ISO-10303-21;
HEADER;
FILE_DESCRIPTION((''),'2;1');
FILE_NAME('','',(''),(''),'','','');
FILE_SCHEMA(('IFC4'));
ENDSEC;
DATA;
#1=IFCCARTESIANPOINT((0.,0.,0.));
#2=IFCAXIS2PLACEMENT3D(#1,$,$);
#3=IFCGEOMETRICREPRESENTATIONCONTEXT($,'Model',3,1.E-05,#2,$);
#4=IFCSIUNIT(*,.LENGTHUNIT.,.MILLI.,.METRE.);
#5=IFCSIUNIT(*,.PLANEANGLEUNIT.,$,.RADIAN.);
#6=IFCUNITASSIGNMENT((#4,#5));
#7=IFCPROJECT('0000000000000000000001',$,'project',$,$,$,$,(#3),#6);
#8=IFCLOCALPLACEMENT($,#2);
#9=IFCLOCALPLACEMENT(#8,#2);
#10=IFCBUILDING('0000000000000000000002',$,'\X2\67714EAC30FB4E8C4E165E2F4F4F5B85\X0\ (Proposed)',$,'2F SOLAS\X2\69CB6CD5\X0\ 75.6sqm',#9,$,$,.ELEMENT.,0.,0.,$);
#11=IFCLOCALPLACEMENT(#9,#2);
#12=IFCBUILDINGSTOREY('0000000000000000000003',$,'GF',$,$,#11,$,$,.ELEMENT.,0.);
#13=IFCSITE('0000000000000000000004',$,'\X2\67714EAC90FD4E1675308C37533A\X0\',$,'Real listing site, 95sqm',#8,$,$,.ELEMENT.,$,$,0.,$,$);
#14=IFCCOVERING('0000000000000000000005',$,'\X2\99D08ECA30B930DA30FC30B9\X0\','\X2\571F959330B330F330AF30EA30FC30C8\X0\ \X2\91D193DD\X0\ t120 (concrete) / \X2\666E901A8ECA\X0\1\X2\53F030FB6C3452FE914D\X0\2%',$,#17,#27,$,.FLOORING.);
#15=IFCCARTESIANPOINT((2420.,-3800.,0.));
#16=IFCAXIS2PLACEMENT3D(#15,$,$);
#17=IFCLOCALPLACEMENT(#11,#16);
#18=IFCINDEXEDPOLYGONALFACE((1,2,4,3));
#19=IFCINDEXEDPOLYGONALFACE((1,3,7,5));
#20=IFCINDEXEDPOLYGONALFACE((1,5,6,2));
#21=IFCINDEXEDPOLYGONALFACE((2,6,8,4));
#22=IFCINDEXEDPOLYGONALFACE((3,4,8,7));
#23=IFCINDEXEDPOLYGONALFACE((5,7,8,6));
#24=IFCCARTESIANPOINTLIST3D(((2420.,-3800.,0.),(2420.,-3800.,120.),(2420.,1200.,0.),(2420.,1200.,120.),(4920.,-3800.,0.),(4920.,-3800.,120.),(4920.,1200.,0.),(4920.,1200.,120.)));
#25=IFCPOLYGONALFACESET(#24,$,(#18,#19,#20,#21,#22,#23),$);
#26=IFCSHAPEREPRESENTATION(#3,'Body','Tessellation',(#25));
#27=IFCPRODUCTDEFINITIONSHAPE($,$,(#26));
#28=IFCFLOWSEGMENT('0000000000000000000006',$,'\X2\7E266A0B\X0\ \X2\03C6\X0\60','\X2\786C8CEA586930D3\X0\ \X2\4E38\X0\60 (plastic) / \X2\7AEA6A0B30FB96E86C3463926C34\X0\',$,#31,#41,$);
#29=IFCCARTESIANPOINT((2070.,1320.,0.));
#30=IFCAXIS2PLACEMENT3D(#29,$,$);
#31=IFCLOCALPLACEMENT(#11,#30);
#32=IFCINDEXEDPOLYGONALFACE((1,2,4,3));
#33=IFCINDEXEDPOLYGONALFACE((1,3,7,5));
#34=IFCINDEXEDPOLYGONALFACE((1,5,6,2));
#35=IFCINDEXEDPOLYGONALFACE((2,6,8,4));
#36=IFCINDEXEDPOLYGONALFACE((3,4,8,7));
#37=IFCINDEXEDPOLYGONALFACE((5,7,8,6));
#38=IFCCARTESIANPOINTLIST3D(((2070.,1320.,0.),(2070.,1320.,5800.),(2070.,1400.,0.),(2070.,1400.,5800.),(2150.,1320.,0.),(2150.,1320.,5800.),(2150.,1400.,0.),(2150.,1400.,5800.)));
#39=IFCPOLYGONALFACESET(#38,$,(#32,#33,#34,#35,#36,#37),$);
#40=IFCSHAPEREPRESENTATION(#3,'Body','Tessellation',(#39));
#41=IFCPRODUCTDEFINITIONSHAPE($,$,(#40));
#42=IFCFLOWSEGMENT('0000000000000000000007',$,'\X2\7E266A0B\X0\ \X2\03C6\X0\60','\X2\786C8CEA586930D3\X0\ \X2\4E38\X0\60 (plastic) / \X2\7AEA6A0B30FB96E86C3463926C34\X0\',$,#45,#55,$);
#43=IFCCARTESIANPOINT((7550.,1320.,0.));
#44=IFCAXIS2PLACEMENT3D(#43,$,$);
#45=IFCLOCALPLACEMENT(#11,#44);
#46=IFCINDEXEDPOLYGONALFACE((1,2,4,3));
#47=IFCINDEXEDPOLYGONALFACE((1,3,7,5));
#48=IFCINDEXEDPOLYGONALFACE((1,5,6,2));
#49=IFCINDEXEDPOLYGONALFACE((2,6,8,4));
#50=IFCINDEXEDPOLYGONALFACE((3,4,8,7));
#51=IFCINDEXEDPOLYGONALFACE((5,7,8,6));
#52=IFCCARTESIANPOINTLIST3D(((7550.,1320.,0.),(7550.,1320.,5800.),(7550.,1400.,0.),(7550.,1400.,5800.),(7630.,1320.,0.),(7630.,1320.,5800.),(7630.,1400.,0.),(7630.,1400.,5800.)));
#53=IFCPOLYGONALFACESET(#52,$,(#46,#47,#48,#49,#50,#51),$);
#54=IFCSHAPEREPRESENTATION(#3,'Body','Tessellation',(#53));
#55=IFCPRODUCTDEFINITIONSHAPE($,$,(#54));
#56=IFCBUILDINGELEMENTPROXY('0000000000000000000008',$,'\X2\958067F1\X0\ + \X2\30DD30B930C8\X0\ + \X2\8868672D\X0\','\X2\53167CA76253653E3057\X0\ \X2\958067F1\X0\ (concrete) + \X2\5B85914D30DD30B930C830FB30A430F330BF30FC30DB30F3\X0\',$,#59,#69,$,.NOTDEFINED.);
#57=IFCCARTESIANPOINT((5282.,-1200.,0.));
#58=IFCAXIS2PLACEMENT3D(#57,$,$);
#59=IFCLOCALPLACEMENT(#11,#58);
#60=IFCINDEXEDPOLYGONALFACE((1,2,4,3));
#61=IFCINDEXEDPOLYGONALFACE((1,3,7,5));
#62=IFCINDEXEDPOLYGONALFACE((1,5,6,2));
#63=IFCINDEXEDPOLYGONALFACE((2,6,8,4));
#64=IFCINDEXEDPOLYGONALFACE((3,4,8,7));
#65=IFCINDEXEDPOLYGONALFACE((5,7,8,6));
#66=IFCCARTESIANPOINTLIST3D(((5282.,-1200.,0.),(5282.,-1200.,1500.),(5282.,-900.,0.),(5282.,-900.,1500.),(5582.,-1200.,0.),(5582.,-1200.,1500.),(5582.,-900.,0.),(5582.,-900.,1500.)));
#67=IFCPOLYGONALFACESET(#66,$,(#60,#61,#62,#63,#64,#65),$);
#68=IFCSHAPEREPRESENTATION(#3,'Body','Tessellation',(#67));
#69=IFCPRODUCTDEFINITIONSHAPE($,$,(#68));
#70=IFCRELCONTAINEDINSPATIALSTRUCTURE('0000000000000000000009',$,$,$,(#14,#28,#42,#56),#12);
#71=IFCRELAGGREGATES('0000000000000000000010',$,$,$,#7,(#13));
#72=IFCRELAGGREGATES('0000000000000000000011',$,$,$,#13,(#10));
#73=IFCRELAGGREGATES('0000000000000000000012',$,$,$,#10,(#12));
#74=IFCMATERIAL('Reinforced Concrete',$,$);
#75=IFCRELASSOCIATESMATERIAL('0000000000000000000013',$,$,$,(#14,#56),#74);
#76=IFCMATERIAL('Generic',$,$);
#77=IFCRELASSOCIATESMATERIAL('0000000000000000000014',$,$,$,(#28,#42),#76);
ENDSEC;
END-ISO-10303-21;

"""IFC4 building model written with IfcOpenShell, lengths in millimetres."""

from ifc_helpers import new_model, si_unit, frame, frame_2d, origin, place, context, project, spatial, rectangle, extrude, material, element, save


model = new_model("IFC4")

# Units and contexts
model_context = context("Model", 3, precision=1e-05, world=origin())
ifc_project = project(units=[si_unit("LENGTHUNIT", "METRE", prefix="MILLI"), si_unit("PLANEANGLEUNIT", "RADIAN")], contexts=[model_context])

# Site, building, storey
site_placement = place(None, origin())
site = spatial("IfcSite", under=ifc_project, at=site_placement, Name="東京都世田谷区", ObjectType="Real listing site, 95sqm", CompositionType="ELEMENT", RefElevation=0.0)
building_placement = place(site_placement, origin())
building = spatial("IfcBuilding", under=site, at=building_placement, Name="東京・二世帯住宅 (Proposed)", ObjectType="2F SOLAS構法 75.6sqm", CompositionType="ELEMENT", ElevationOfRefHeight=0.0, ElevationOfTerrain=0.0)
storey_placement = place(building_placement, origin())
storey = spatial("IfcBuildingStorey", under=building, at=storey_placement, Name="GF", CompositionType="ELEMENT", Elevation=0.0)

# Shared definitions
ifc_material_1 = material(Name="Reinforced Concrete")

# Covering
covering_1_placement = place(storey_placement, frame((2420.0, -3800.0, 0.0)))
element("IfcCovering", 1, at=covering_1_placement, inside=storey, material=ifc_material_1, Name="駐車スペース", Description="土間コンクリート 金鏝 t120 (concrete) / 普通車1台・水勾配2%", PredefinedType="FLOORING", context=model_context, shape_type="SweptSolid", body=[
    extrude(rectangle(XDim=2500.0, YDim=5000.0, at=frame_2d((1250.0, 2500.0))), frame((2420.0, -3800.0, 0.0)), (0.0, 0.0, 1.0), 120.0),
])

# Flow segments
ifc_material_2 = material(Name="Generic")
flow_segment_1_placement = place(storey_placement, frame((2070.0, 1320.0, 0.0)))
element("IfcFlowSegment", 2, at=flow_segment_1_placement, inside=storey, material=ifc_material_2, Name="縦樋 φ60", Description="硬質塩ビ 丸60 (plastic) / 竪樋・雨水排水", context=model_context, shape_type="SweptSolid", body=[
    extrude(rectangle(XDim=80.0, YDim=80.0, at=frame_2d((40.0, 40.0))), frame((2070.0, 1320.0, 0.0)), (0.0, 0.0, 1.0), 5800.0),
])
flow_segment_2_placement = place(storey_placement, frame((7550.0, 1320.0, 0.0)))
element("IfcFlowSegment", 3, at=flow_segment_2_placement, inside=storey, material=ifc_material_2, Name="縦樋 φ60", Description="硬質塩ビ 丸60 (plastic) / 竪樋・雨水排水", context=model_context, shape_type="SweptSolid", body=[
    extrude(rectangle(XDim=80.0, YDim=80.0, at=frame_2d((40.0, 40.0))), frame((7550.0, 1320.0, 0.0)), (0.0, 0.0, 1.0), 5800.0),
])

# Building element proxy
proxy_placement = place(storey_placement, frame((5282.0, -1200.0, 0.0)))
element("IfcBuildingElementProxy", 4, at=proxy_placement, inside=storey, material=ifc_material_1, Name="門柱 + ポスト + 表札", Description="化粧打放し 門柱 (concrete) + 宅配ポスト・インターホン", PredefinedType="NOTDEFINED", context=model_context, shape_type="SweptSolid", body=[
    extrude(rectangle(XDim=300.0, YDim=300.0, at=frame_2d((150.0, 150.0))), frame((5282.0, -1200.0, 0.0)), (0.0, 0.0, 1.0), 1500.0),
])

save(model, "model.ifc")
